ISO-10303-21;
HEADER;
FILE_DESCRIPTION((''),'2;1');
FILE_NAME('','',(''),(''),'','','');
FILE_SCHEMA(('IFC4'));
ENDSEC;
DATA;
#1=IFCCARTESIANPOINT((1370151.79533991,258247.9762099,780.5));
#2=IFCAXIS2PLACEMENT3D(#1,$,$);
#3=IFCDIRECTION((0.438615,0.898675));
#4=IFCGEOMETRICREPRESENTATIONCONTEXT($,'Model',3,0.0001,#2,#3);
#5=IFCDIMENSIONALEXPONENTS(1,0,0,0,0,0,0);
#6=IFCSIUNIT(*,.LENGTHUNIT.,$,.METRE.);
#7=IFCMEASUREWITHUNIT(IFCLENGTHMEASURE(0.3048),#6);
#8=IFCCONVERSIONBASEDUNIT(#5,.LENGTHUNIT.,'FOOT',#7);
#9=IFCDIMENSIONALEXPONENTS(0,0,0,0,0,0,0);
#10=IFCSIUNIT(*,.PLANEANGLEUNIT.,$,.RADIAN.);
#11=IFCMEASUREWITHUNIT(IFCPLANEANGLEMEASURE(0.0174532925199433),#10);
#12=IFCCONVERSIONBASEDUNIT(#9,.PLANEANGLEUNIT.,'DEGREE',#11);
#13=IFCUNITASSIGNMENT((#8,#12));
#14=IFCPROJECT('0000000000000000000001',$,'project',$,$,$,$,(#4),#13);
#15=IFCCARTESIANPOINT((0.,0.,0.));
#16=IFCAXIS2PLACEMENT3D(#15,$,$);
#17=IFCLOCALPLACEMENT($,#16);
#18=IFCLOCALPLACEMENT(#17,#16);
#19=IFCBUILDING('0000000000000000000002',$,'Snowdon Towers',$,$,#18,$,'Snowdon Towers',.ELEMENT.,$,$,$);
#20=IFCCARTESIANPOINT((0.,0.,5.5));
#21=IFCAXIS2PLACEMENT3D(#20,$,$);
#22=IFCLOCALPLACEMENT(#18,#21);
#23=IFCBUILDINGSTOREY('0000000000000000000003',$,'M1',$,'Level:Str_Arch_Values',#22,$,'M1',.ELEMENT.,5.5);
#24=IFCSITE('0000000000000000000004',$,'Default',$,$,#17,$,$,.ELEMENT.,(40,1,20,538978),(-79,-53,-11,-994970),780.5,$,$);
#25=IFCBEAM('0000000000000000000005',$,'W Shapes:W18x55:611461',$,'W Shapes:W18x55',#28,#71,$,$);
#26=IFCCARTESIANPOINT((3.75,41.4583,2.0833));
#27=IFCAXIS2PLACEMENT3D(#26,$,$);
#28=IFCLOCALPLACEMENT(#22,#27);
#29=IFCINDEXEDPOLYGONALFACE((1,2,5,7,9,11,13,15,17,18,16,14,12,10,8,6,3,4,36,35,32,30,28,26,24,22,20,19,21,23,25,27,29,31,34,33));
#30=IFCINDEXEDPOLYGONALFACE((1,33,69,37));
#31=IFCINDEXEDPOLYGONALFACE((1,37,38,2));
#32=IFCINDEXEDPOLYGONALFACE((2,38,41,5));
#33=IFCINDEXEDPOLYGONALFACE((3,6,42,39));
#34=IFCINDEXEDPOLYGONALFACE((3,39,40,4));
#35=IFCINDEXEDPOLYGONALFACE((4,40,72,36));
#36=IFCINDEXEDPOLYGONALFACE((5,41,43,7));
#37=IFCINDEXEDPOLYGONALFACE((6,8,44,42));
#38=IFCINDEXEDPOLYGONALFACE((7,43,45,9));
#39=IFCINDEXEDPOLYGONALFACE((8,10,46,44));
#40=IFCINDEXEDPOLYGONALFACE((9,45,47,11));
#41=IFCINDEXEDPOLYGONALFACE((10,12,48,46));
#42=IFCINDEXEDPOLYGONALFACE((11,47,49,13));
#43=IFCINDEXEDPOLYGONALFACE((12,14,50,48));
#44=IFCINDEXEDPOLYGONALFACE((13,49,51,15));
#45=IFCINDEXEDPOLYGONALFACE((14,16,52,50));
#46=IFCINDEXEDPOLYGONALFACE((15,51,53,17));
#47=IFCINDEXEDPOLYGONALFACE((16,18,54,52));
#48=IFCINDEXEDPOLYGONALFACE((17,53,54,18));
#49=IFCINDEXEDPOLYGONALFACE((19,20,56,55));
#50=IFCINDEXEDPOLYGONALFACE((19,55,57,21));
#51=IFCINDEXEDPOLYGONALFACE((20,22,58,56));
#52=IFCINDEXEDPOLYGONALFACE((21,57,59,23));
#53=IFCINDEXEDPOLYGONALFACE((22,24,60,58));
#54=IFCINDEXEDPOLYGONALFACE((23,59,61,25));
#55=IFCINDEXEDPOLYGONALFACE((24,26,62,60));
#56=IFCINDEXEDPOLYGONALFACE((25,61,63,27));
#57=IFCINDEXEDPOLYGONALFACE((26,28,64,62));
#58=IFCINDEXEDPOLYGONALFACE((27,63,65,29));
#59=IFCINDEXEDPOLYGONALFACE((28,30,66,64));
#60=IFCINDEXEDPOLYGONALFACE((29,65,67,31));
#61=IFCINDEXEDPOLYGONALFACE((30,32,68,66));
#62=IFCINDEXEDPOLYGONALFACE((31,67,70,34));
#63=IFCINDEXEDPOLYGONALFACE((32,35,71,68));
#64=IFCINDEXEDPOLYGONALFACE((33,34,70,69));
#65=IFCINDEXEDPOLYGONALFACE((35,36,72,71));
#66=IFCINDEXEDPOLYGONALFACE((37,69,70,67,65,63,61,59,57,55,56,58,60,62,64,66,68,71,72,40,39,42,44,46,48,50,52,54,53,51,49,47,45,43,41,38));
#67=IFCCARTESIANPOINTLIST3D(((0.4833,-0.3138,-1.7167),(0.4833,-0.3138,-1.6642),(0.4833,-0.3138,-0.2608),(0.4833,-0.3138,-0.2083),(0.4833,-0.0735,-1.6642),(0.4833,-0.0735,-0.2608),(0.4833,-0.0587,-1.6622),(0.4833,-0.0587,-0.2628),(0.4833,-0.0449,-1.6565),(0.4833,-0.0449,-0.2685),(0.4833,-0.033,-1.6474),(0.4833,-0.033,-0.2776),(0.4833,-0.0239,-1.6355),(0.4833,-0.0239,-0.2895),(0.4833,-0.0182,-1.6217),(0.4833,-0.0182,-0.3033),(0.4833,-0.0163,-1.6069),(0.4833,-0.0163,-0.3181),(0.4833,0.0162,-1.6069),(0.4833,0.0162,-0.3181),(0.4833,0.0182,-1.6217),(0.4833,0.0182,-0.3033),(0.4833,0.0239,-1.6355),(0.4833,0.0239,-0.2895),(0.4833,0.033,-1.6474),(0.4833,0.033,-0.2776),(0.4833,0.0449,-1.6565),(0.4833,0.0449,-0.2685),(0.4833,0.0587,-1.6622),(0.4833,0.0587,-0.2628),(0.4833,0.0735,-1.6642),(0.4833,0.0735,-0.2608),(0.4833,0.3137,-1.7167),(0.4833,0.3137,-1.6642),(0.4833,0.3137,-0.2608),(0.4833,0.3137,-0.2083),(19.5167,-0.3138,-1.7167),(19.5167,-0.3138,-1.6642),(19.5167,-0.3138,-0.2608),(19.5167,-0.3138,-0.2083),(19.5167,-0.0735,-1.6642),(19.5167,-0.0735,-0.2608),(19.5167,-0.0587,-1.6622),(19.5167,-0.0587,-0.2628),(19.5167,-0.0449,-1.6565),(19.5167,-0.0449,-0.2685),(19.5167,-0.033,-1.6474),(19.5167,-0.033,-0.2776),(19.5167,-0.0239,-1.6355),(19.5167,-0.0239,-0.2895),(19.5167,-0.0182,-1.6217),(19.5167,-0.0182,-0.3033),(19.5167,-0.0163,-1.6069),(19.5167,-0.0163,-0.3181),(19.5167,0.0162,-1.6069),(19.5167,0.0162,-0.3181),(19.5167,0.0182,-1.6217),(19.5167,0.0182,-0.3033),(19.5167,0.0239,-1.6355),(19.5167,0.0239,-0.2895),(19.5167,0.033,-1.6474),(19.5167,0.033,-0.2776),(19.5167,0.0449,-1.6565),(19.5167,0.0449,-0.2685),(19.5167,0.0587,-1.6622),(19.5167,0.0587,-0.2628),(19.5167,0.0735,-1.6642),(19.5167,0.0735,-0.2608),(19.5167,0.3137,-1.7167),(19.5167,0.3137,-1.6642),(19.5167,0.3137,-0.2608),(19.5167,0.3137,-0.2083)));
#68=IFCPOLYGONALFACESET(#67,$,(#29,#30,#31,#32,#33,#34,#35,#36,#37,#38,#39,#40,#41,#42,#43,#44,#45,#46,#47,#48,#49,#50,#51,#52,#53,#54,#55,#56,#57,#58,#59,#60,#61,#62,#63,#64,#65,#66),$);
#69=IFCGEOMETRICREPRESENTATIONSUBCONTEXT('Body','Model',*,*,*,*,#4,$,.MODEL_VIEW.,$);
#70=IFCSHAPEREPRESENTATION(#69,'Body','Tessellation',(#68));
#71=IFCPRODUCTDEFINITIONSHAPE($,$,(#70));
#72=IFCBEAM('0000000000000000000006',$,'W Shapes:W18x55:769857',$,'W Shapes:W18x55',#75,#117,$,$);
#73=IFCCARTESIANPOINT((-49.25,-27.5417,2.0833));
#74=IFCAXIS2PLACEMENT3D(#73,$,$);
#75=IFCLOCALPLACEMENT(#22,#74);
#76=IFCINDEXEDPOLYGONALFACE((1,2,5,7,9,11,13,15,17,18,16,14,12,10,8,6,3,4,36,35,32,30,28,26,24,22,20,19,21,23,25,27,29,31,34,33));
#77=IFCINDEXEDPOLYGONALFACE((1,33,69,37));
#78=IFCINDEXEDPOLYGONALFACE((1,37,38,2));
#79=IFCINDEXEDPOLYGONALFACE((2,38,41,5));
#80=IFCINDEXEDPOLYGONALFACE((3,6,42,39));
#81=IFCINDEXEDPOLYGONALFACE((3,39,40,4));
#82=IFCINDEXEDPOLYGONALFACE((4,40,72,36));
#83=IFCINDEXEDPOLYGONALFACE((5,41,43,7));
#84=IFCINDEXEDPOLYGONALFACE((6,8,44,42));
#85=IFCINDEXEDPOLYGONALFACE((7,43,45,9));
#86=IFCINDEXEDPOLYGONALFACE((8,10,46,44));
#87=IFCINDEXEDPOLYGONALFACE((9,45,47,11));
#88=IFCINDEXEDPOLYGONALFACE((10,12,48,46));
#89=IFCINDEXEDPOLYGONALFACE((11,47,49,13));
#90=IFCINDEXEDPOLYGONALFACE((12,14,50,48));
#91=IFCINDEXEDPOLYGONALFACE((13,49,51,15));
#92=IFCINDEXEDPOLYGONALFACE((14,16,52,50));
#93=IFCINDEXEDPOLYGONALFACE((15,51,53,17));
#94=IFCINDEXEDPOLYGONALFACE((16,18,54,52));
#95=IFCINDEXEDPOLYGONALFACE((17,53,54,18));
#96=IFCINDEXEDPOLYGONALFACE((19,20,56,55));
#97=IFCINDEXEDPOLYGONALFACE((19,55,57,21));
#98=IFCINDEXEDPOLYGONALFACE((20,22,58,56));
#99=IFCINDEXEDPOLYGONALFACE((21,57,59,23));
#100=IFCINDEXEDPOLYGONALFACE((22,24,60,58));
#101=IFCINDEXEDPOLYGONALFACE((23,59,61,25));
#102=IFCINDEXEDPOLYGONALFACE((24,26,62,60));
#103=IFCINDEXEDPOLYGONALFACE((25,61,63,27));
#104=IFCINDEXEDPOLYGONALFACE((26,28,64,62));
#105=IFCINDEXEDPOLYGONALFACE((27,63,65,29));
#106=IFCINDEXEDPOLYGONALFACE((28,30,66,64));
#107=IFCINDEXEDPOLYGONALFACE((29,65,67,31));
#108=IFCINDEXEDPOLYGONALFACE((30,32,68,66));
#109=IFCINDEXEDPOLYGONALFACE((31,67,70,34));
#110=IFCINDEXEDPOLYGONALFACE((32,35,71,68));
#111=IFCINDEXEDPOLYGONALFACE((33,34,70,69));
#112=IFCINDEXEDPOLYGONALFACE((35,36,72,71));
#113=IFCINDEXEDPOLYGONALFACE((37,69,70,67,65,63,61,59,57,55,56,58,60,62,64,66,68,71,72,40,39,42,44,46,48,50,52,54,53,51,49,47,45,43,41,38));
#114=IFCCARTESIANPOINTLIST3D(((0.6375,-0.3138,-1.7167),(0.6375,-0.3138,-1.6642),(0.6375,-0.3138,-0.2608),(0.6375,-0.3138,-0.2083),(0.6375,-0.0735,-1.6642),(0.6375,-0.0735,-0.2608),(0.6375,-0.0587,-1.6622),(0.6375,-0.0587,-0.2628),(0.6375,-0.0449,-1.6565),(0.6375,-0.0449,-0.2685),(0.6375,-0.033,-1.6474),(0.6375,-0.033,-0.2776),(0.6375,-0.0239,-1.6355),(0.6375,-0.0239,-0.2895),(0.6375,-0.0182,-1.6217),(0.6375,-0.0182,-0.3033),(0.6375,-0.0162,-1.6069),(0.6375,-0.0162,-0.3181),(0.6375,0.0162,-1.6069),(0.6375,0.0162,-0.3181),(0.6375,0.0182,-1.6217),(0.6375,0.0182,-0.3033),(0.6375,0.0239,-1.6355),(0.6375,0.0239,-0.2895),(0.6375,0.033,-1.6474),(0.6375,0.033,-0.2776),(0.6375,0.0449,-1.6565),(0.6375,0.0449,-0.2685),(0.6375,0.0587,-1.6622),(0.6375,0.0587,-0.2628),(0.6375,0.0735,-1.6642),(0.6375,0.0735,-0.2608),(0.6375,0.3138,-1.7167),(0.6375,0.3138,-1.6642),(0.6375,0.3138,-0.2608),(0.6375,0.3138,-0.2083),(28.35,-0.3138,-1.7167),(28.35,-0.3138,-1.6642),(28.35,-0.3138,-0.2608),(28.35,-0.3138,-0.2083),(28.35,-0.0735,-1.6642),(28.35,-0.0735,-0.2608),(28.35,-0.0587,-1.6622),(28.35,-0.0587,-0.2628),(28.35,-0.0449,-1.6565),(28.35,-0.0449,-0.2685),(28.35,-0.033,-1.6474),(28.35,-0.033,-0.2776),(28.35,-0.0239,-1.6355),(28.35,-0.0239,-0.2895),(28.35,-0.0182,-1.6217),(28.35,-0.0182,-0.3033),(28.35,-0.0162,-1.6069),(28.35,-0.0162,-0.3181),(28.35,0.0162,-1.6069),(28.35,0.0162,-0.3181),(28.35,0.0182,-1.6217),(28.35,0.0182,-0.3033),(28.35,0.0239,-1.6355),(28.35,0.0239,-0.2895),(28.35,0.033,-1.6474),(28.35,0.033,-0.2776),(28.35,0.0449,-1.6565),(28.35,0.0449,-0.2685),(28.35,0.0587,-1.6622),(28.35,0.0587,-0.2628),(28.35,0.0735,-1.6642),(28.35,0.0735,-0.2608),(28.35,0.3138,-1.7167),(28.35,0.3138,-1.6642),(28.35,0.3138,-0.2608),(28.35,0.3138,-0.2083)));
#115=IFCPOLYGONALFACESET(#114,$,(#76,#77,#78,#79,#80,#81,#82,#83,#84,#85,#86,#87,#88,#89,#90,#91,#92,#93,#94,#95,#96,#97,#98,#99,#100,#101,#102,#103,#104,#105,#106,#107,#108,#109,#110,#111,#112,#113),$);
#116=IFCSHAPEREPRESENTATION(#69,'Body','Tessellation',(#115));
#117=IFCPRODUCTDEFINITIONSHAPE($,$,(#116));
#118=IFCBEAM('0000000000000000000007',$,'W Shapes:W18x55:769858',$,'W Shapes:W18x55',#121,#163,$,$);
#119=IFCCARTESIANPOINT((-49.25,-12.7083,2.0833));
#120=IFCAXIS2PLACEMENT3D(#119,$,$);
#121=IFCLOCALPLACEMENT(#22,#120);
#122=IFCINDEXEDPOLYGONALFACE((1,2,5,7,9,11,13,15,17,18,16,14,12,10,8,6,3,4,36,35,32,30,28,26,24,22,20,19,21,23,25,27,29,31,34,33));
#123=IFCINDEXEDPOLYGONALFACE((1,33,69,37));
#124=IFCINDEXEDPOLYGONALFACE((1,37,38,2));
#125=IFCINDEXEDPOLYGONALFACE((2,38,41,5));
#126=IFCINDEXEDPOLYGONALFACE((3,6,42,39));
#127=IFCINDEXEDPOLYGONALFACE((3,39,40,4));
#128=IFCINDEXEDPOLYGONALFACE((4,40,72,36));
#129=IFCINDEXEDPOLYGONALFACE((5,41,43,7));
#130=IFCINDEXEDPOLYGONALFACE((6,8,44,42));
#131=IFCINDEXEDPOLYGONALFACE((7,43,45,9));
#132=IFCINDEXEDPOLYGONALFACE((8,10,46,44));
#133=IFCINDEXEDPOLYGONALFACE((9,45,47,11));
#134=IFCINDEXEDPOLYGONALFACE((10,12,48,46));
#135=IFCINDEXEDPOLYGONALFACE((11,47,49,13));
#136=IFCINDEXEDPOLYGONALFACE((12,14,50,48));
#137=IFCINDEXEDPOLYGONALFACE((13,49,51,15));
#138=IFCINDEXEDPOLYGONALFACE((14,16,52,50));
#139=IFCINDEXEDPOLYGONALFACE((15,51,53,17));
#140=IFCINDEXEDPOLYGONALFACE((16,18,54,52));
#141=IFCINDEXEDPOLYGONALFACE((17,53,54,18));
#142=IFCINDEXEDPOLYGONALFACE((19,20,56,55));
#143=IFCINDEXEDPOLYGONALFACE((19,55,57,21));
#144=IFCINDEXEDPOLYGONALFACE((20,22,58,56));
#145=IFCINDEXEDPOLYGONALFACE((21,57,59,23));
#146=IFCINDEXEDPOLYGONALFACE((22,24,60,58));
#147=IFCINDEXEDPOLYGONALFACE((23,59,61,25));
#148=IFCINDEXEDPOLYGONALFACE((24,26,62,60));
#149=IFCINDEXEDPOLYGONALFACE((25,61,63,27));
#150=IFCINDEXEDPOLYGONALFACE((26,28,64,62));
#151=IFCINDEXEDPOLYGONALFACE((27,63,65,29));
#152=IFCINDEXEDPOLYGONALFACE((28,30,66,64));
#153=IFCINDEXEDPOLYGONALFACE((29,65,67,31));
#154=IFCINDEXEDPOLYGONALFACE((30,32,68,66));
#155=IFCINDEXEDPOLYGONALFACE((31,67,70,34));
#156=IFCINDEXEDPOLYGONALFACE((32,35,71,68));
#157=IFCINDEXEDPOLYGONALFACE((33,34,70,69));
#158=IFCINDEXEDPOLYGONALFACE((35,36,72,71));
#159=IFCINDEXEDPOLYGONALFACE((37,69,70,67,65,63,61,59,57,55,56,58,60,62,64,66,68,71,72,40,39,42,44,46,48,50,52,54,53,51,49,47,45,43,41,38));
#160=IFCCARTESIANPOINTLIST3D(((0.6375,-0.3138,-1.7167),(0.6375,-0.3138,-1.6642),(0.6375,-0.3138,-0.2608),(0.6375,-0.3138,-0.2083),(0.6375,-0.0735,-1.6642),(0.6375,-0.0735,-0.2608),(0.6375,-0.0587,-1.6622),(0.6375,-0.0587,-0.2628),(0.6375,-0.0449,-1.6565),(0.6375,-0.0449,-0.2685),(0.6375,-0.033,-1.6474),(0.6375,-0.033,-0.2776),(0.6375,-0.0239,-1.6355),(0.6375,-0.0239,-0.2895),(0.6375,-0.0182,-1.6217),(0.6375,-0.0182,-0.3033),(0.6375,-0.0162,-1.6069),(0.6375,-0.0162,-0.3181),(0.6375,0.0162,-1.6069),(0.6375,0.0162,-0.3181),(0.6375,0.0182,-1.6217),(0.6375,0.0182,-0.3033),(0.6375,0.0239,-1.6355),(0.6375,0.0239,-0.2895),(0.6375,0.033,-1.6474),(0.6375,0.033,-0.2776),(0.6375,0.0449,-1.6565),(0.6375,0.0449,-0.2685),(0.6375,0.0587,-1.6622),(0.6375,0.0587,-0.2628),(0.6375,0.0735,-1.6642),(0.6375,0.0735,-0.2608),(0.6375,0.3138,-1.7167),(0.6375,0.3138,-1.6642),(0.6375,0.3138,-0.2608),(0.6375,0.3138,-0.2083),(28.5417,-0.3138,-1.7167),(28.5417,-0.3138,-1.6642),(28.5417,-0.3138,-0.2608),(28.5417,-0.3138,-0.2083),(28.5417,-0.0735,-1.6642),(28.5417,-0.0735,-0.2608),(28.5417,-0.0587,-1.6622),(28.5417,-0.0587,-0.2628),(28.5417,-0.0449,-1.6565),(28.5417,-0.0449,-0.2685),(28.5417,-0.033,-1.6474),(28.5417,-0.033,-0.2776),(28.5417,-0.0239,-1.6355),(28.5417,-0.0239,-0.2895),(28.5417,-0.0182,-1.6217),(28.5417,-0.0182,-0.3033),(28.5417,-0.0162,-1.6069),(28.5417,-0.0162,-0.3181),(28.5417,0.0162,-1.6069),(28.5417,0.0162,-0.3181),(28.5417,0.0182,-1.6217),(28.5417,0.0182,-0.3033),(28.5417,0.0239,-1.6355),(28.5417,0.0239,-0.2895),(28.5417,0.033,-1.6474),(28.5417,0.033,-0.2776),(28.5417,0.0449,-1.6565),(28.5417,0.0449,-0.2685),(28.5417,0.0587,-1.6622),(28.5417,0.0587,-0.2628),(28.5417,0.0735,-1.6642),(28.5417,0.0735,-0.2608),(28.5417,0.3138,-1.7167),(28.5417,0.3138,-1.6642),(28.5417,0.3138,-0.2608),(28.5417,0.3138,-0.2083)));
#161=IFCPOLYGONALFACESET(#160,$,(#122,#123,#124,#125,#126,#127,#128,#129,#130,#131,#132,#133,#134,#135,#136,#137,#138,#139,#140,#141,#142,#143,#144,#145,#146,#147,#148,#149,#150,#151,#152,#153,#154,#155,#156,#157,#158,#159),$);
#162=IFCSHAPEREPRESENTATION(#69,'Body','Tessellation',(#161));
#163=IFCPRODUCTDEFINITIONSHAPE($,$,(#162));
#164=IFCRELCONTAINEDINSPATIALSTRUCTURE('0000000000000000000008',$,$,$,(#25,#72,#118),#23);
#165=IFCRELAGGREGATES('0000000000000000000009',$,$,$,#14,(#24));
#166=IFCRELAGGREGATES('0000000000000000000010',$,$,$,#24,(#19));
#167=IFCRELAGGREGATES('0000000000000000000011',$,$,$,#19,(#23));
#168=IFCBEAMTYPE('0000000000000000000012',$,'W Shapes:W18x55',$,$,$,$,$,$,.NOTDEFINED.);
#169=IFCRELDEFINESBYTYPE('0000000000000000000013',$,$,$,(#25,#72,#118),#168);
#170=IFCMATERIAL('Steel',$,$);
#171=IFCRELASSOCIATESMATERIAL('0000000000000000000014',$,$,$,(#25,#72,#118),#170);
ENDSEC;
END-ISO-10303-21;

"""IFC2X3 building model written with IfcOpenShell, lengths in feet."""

from ifc_helpers import new_model, entity, si_unit, converted_unit, direction, frame, frame_2d, origin, place, context, subcontext, project, spatial, i_section, extrude, material, type_object, element, save


model = new_model("IFC2X3")

# Units and contexts
model_context = context("Model", 3, precision=0.0001, world=frame((1370151.79533991, 258247.9762099, 780.5)), true_north=direction((0.438615, 0.898675)))
body_context = subcontext(model_context, "Body", "Model", "MODEL_VIEW")
ifc_project = project(units=[converted_unit("LENGTHUNIT", "FOOT", entity("IfcLengthMeasure", 0.3048), si_unit("LENGTHUNIT", "METRE"), dimensions=[1, 0, 0, 0, 0, 0, 0]), converted_unit("PLANEANGLEUNIT", "DEGREE", entity("IfcPlaneAngleMeasure", 0.0174532925199433), si_unit("PLANEANGLEUNIT", "RADIAN"), dimensions=[0, 0, 0, 0, 0, 0, 0])], contexts=[model_context])

# Site, building, storey
site_placement = place(None, origin())
site = spatial("IfcSite", under=ifc_project, at=site_placement, Name="Default", CompositionType="ELEMENT", RefLatitude=(40, 1, 20, 538978), RefLongitude=(-79, -53, -11, -994970), RefElevation=780.5)
building_placement = place(site_placement, origin())
building = spatial("IfcBuilding", under=site, at=building_placement, Name="Snowdon Towers", LongName="Snowdon Towers", CompositionType="ELEMENT")
storey_placement = place(building_placement, frame((0.0, 0.0, 5.5)))
storey = spatial("IfcBuildingStorey", under=building, at=storey_placement, Name="M1", ObjectType="Level:Str_Arch_Values", LongName="M1", CompositionType="ELEMENT", Elevation=5.5)

# Beams
ifc_material_1 = material(Name="Steel")
beam_type_1 = type_object("IfcBeamType", Name="W Shapes:W18x55", PredefinedType="NOTDEFINED")
beam_1_placement = place(storey_placement, frame((3.75, 41.4583, 2.0833)))
element("IfcBeam", 1, at=beam_1_placement, inside=storey, type_object=beam_type_1, material=ifc_material_1, Name="W Shapes:W18x55:611461", ObjectType="W Shapes:W18x55", context=body_context, shape_type="SweptSolid", body=[
    extrude(i_section(OverallWidth=0.6275, OverallDepth=1.5083, WebThickness=0.0325, FlangeThickness=0.0525, FilletRadius=0.0573, at=frame_2d((0.0, 0.0), x_axis=(0.0, 1.0))), frame((0.4833, 0.0, -0.9625), z_axis=(1.0, 0.0, 0.0), x_axis=(0.0, 0.0, -1.0)), (0.0, 0.0, 1.0), 19.0333),
])
beam_2_placement = place(storey_placement, frame((-49.25, -27.5417, 2.0833)))
element("IfcBeam", 2, at=beam_2_placement, inside=storey, type_object=beam_type_1, material=ifc_material_1, Name="W Shapes:W18x55:769857", ObjectType="W Shapes:W18x55", context=body_context, shape_type="SweptSolid", body=[
    extrude(i_section(OverallWidth=0.6275, OverallDepth=1.5083, WebThickness=0.0325, FlangeThickness=0.0525, FilletRadius=0.0573, at=frame_2d((0.0, 0.0), x_axis=(0.0, 1.0))), frame((0.6375, 0.0, -0.9625), z_axis=(1.0, 0.0, 0.0), x_axis=(0.0, 0.0, -1.0)), (0.0, 0.0, 1.0), 27.7125),
])
beam_3_placement = place(storey_placement, frame((-49.25, -12.7083, 2.0833)))
element("IfcBeam", 3, at=beam_3_placement, inside=storey, type_object=beam_type_1, material=ifc_material_1, Name="W Shapes:W18x55:769858", ObjectType="W Shapes:W18x55", context=body_context, shape_type="SweptSolid", body=[
    extrude(i_section(OverallWidth=0.6275, OverallDepth=1.5083, WebThickness=0.0325, FlangeThickness=0.0525, FilletRadius=0.0573, at=frame_2d((0.0, 0.0), x_axis=(0.0, 1.0))), frame((0.6375, 0.0, -0.9625), z_axis=(1.0, 0.0, 0.0), x_axis=(0.0, 0.0, -1.0)), (0.0, 0.0, 1.0), 27.9042),
])

save(model, "model.ifc")
